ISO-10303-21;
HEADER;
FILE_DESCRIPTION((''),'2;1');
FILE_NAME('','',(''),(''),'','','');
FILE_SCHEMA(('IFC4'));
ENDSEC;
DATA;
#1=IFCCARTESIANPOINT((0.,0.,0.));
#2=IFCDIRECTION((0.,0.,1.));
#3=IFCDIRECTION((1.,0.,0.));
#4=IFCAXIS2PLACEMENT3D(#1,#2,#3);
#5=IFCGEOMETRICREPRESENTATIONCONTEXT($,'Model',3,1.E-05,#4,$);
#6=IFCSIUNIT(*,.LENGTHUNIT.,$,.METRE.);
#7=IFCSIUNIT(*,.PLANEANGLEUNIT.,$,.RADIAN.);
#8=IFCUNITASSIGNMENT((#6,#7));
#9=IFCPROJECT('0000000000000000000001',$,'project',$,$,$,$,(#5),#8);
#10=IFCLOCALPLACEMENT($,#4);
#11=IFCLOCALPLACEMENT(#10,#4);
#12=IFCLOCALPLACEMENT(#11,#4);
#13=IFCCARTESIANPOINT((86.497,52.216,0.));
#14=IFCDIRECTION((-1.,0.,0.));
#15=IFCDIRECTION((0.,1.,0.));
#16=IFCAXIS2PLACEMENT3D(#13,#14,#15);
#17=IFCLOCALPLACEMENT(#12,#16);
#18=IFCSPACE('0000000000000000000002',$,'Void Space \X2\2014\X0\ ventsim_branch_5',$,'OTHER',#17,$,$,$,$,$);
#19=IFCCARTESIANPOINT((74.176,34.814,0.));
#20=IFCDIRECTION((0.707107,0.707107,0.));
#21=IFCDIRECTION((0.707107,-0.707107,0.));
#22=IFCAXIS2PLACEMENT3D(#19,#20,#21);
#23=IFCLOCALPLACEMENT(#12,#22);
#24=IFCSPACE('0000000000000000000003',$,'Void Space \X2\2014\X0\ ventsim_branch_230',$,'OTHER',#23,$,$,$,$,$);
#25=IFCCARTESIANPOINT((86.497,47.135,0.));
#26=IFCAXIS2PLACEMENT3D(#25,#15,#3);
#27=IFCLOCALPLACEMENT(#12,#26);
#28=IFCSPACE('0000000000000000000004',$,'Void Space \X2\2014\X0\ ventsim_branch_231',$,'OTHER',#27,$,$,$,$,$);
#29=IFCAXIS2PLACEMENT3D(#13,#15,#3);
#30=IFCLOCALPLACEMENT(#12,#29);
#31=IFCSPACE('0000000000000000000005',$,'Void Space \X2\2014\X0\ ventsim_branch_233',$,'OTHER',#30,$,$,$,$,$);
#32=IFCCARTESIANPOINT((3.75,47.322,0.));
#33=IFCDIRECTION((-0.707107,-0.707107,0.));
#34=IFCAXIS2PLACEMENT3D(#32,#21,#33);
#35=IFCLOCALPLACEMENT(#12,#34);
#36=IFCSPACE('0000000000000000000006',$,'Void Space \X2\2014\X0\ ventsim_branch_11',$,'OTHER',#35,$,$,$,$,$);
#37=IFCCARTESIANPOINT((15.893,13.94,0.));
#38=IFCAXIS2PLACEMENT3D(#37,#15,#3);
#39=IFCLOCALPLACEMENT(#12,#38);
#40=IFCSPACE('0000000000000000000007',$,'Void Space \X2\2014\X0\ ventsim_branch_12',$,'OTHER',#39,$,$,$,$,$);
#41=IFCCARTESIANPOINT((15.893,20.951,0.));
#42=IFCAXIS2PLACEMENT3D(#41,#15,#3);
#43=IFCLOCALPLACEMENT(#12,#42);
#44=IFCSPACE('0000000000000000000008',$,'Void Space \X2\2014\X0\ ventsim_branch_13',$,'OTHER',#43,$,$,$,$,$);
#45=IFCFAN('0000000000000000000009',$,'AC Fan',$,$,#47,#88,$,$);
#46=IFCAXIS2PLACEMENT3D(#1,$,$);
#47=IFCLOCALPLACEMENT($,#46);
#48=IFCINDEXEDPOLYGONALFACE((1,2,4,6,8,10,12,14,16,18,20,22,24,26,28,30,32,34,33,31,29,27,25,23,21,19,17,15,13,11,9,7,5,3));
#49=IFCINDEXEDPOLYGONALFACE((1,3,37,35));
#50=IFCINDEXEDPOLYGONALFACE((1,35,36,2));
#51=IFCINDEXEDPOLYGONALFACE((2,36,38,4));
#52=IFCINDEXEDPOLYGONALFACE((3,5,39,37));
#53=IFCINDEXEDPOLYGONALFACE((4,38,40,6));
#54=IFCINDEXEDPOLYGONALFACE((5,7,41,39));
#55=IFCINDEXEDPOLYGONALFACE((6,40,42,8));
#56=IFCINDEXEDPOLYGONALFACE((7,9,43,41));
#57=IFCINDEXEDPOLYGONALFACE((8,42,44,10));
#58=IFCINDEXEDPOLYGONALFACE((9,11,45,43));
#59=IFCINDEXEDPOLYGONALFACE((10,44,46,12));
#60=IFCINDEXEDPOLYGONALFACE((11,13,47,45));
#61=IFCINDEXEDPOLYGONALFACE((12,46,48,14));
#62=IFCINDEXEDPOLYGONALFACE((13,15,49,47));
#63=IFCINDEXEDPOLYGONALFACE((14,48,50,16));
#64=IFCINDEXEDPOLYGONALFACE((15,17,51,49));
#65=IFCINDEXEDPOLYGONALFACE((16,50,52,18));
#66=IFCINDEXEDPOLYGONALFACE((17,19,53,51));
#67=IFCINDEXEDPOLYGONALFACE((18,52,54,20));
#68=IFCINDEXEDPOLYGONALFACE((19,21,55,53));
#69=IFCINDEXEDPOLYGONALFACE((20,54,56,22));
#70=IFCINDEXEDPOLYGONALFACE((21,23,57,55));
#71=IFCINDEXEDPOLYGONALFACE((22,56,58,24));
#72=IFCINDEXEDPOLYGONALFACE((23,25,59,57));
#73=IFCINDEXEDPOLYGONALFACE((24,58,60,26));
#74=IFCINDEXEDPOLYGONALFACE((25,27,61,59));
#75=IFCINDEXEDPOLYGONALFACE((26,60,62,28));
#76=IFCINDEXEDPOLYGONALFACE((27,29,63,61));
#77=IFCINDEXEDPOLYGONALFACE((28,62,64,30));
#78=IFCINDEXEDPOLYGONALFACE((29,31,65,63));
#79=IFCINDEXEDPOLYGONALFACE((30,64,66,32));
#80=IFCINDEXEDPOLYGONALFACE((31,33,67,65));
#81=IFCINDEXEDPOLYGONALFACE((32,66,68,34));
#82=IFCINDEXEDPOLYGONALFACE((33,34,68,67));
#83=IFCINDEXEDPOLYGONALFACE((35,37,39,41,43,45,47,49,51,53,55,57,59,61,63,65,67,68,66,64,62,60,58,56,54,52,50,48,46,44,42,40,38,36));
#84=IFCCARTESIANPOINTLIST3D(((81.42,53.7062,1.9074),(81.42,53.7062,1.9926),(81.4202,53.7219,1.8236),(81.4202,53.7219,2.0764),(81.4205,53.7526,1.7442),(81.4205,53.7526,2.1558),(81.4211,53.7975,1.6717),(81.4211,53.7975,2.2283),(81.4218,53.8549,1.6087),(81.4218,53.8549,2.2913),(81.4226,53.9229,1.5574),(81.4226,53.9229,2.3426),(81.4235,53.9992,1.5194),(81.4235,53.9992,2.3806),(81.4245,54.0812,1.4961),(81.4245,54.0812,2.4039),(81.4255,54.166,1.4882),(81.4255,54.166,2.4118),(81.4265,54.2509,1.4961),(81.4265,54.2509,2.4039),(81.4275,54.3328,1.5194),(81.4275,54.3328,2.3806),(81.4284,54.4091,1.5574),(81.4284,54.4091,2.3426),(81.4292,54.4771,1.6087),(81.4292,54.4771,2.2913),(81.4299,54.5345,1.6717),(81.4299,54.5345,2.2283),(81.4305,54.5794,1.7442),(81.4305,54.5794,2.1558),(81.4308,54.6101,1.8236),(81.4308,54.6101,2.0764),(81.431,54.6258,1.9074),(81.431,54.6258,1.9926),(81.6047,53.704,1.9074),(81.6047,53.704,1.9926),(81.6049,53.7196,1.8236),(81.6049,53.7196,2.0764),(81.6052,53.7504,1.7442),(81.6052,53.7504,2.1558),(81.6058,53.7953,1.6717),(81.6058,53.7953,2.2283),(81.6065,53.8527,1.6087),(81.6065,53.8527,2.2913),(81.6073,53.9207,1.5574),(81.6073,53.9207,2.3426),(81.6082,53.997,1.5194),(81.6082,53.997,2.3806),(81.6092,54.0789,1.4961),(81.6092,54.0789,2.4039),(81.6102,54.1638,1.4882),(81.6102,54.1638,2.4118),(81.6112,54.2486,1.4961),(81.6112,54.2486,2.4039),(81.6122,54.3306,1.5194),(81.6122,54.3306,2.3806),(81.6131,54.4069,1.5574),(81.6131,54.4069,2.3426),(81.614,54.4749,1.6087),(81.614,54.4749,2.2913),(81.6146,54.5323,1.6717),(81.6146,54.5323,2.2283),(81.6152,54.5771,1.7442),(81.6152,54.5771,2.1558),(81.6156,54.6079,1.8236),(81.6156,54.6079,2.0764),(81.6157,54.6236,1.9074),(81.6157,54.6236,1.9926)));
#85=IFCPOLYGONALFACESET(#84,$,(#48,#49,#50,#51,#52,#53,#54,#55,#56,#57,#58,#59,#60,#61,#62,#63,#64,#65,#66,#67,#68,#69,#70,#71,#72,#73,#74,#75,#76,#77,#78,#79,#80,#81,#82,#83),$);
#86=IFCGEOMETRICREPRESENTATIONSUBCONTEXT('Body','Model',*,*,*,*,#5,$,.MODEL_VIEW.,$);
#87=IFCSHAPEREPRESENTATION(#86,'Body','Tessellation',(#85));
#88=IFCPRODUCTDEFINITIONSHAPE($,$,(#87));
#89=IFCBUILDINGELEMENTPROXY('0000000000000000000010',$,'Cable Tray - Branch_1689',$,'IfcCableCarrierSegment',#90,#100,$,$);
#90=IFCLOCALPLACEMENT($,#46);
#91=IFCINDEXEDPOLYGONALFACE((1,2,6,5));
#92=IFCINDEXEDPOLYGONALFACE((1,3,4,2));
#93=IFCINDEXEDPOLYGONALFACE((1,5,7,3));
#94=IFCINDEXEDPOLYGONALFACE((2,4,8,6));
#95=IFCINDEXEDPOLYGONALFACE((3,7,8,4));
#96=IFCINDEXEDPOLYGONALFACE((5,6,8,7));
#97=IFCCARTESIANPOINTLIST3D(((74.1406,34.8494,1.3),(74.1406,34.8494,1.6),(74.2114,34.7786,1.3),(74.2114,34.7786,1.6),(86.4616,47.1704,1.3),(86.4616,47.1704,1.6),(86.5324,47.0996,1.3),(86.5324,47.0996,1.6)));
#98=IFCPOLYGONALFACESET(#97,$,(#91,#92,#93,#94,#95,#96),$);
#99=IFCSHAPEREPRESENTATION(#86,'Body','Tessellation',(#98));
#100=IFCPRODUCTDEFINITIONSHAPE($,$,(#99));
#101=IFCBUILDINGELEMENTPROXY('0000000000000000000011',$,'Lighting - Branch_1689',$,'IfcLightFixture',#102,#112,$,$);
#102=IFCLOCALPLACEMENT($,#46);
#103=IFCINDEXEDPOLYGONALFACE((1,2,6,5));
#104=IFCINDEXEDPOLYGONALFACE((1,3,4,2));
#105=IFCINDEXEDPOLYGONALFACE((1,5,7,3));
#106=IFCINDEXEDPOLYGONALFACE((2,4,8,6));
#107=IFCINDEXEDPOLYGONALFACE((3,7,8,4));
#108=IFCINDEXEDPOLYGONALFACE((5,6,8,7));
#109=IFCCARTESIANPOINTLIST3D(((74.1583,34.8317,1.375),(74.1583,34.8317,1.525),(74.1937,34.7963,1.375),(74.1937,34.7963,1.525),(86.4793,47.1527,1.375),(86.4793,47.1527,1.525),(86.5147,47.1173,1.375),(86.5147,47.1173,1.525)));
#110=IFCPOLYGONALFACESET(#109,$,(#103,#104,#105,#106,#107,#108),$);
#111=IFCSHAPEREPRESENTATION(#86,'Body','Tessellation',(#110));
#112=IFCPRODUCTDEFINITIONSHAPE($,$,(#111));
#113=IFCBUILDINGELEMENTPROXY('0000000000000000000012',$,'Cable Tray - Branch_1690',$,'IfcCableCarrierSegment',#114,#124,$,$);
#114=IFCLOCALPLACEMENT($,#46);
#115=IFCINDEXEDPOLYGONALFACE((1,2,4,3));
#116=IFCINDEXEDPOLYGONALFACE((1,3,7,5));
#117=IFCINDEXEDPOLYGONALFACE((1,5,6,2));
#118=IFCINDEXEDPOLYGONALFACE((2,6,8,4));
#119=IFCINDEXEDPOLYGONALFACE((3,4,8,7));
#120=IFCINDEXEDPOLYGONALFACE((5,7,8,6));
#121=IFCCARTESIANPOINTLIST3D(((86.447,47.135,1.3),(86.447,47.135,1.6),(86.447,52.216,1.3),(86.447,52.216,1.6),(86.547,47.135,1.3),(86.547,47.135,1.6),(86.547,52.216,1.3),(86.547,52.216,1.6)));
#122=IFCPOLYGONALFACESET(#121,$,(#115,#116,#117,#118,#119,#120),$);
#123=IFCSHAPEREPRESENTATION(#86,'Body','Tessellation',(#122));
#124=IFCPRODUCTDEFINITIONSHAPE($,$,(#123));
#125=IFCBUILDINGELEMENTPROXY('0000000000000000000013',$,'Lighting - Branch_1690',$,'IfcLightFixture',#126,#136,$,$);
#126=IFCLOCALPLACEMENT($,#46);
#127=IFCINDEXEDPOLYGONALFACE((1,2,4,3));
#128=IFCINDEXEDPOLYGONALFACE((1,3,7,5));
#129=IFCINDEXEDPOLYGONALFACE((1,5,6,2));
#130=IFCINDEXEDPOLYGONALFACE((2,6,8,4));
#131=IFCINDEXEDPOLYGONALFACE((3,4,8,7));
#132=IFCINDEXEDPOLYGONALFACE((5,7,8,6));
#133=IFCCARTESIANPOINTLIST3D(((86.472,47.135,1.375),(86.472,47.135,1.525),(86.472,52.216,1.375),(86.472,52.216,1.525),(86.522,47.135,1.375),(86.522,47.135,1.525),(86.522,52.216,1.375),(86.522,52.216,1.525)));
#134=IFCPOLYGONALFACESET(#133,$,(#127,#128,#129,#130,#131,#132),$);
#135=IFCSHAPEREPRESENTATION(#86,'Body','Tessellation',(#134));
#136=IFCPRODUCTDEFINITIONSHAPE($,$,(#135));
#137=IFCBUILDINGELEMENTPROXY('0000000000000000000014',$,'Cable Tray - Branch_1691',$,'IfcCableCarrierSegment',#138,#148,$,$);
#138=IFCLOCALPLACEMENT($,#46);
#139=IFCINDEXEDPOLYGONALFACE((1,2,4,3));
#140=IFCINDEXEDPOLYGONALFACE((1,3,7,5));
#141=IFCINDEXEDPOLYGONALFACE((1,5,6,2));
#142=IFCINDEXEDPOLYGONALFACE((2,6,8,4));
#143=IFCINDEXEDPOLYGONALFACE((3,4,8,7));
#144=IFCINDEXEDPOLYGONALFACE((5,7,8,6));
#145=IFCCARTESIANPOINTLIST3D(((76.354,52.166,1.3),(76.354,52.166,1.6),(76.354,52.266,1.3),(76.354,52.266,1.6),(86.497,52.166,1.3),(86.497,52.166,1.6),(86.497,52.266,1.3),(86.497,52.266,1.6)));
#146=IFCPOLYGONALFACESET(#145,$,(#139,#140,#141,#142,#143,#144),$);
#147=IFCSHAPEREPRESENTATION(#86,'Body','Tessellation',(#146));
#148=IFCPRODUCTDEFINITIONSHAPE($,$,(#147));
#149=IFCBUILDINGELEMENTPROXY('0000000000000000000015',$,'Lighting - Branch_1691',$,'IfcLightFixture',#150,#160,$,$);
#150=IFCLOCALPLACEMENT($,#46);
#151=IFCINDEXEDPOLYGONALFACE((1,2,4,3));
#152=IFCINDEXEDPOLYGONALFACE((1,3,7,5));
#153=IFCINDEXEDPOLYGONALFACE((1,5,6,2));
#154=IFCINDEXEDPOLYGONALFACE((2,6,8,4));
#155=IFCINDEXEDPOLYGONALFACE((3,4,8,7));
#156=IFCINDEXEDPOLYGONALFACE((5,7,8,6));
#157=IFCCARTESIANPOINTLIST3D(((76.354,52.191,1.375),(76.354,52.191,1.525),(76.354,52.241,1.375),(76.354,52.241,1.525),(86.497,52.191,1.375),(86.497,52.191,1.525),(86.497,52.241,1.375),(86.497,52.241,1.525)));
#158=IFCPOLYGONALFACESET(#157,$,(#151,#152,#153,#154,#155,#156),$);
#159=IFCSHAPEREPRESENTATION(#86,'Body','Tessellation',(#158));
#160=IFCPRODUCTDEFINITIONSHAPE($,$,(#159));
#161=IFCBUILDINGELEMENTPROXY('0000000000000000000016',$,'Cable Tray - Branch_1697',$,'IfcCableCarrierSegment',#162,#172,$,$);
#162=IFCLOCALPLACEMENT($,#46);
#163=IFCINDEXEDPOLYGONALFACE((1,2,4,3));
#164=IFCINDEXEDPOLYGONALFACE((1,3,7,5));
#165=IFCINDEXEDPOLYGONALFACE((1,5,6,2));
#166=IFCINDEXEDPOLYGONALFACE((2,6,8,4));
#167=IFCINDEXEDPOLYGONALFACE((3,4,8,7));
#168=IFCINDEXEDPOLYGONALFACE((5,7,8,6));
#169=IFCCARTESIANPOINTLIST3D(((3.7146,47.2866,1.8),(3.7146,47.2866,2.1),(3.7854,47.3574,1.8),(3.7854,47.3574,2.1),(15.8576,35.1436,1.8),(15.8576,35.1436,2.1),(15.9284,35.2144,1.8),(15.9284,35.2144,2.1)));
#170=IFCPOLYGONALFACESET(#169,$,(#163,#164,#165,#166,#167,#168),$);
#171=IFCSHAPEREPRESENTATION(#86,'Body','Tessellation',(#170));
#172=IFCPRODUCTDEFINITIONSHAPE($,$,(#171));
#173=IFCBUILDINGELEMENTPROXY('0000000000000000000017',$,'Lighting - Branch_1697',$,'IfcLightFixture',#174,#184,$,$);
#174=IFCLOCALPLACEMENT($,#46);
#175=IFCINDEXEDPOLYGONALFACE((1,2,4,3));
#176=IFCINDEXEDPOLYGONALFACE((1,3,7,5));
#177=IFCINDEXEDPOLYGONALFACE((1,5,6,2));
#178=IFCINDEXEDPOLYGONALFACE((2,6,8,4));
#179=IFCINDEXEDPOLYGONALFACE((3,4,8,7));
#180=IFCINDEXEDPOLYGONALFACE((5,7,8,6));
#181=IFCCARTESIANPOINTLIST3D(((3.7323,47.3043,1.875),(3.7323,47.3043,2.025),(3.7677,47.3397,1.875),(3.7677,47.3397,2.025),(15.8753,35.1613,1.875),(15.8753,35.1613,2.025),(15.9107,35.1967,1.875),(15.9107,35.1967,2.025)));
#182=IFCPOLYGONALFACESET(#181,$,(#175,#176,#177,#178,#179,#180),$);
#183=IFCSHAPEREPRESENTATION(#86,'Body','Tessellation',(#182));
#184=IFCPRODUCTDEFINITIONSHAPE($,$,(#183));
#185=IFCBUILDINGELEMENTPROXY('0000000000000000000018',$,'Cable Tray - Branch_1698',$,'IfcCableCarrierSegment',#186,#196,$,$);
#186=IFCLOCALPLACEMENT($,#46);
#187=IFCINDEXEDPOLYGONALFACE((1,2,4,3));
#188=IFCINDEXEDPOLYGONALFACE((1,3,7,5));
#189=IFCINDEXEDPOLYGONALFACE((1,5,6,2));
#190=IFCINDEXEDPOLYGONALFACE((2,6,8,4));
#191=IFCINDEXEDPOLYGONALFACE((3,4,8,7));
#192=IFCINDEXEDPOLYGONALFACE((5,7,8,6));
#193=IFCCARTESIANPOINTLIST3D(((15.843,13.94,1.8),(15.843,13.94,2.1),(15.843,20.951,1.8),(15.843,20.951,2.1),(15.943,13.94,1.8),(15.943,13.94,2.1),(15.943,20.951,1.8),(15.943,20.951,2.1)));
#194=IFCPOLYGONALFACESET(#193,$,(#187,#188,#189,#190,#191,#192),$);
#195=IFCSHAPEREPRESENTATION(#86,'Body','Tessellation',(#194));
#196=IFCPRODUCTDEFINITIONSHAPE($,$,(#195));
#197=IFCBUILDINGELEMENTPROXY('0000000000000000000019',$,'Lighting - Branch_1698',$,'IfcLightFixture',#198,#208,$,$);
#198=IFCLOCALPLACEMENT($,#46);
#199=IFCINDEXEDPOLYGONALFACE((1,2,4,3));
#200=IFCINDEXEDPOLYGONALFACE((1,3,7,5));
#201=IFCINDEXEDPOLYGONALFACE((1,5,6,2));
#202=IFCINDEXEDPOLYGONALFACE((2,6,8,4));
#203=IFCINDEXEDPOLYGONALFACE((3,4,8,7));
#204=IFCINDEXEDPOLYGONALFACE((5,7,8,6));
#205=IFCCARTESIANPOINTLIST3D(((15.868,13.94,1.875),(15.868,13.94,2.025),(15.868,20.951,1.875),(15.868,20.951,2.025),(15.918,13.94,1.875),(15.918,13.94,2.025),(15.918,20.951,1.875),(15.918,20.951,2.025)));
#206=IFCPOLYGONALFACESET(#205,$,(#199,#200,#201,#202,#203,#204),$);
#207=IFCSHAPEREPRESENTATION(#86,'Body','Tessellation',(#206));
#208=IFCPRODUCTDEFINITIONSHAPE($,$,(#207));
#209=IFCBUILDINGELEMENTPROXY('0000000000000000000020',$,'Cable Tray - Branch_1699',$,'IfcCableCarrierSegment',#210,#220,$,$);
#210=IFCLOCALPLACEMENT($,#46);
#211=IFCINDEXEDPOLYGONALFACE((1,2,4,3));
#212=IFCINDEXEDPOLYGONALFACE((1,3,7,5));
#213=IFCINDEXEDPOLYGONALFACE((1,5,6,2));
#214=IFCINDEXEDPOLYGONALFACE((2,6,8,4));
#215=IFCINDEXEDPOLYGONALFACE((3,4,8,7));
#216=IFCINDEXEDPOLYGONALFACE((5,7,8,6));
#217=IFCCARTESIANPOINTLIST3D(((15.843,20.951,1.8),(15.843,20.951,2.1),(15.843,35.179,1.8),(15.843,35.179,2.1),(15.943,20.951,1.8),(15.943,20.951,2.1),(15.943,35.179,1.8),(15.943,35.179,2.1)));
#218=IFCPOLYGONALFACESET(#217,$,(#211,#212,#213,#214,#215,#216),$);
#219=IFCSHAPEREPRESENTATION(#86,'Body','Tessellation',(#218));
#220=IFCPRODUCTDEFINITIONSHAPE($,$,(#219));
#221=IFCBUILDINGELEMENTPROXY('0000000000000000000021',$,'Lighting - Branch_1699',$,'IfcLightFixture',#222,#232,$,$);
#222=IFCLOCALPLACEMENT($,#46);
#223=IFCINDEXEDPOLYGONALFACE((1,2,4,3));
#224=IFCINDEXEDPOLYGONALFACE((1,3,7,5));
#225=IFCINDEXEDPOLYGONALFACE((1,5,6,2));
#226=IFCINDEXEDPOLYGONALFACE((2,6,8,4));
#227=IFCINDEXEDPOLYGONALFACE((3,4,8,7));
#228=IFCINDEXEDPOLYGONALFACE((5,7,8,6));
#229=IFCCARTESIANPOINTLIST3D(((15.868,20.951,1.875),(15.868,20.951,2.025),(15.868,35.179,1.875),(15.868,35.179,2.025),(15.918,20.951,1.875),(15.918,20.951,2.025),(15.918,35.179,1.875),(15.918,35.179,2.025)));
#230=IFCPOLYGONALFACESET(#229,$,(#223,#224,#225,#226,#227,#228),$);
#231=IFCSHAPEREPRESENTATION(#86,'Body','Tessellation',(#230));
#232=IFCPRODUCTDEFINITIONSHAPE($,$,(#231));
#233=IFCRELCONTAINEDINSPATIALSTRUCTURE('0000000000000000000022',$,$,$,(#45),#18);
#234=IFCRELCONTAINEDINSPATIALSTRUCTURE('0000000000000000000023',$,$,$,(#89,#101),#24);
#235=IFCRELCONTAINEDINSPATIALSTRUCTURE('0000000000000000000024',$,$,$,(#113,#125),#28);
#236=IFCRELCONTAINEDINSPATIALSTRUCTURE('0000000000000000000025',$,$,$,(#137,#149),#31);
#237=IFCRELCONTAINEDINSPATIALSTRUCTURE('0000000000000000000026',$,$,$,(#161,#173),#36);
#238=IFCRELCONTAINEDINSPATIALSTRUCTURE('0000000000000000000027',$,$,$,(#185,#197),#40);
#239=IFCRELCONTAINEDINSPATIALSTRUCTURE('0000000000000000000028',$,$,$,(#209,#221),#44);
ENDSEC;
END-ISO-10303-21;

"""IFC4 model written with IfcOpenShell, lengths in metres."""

from ifc_helpers import new_model, si_unit, frame, origin_with_axes, origin_2d_with_axis, place, context, subcontext, project, spatial, rectangle, circle, extrude, element, save


model = new_model("IFC4")

# Units and contexts
model_context = context("Model", 3, precision=1e-05, world=origin_with_axes())
body_context = subcontext(model_context, "Body", "Model", "MODEL_VIEW")
ifc_project = project(units=[si_unit("LENGTHUNIT", "METRE"), si_unit("PLANEANGLEUNIT", "RADIAN")], contexts=[model_context])

# Space
placement_1 = place(None, origin_with_axes())
placement_2 = place(placement_1, origin_with_axes())
placement_3 = place(placement_2, origin_with_axes())
space_1_placement = place(placement_3, frame((86.497, 52.216, 0.0), z_axis=(-1.0, 0.0, 0.0), x_axis=(0.0, 1.0, 0.0)))
space_1 = spatial("IfcSpace", at=space_1_placement, Name="Void Space — ventsim_branch_5", ObjectType="OTHER")

# Fan
fan_placement = place(placement_3, frame((81.4255, 54.166, 1.95), z_axis=(0.999928, -0.012018, 0.0), x_axis=(0.0, 0.0, 1.0)))
element("IfcFan", 1, at=fan_placement, inside=space_1, Name="AC Fan", context=body_context, shape_type="SweptSolid", body=[
    extrude(circle(Radius=0.4618, at=origin_2d_with_axis()), origin_with_axes(), (0.0, 0.0, 1.0), 0.1847),
])

# Shared definitions
space_2_placement = place(placement_3, frame((74.176, 34.814, 0.0), z_axis=(0.707107, 0.707107, 0.0), x_axis=(0.707107, -0.707107, 0.0)))
space_2 = spatial("IfcSpace", at=space_2_placement, Name="Void Space — ventsim_branch_230", ObjectType="OTHER")

# Building element proxies
proxy_1_placement = place(placement_3, frame((74.176, 34.814, 1.45), z_axis=(0.707107, 0.707107, 0.0), x_axis=(0.0, 0.0, 1.0)))
element("IfcBuildingElementProxy", 2, at=proxy_1_placement, inside=space_2, Name="Cable Tray - Branch_1689", ObjectType="IfcCableCarrierSegment", context=body_context, shape_type="SweptSolid", body=[
    extrude(rectangle(XDim=0.3, YDim=0.1, at=origin_2d_with_axis()), origin_with_axes(), (0.0, 0.0, 1.0), 17.4245),
])
proxy_2_placement = place(placement_3, frame((74.176, 34.814, 1.45), z_axis=(0.707107, 0.707107, 0.0), x_axis=(0.0, 0.0, 1.0)))
element("IfcBuildingElementProxy", 3, at=proxy_2_placement, inside=space_2, Name="Lighting - Branch_1689", ObjectType="IfcLightFixture", context=body_context, shape_type="SweptSolid", body=[
    extrude(rectangle(XDim=0.15, YDim=0.05, at=origin_2d_with_axis()), origin_with_axes(), (0.0, 0.0, 1.0), 17.4245),
])

# Shared definitions
space_3_placement = place(placement_3, frame((86.497, 47.135, 0.0), z_axis=(0.0, 1.0, 0.0), x_axis=(1.0, 0.0, 0.0)))
space_3 = spatial("IfcSpace", at=space_3_placement, Name="Void Space — ventsim_branch_231", ObjectType="OTHER")

# Building element proxies
proxy_3_placement = place(placement_3, frame((86.497, 47.135, 1.45), z_axis=(0.0, 1.0, 0.0), x_axis=(0.0, 0.0, 1.0)))
element("IfcBuildingElementProxy", 4, at=proxy_3_placement, inside=space_3, Name="Cable Tray - Branch_1690", ObjectType="IfcCableCarrierSegment", context=body_context, shape_type="SweptSolid", body=[
    extrude(rectangle(XDim=0.3, YDim=0.1, at=origin_2d_with_axis()), origin_with_axes(), (0.0, 0.0, 1.0), 5.081),
])
proxy_4_placement = place(placement_3, frame((86.497, 47.135, 1.45), z_axis=(0.0, 1.0, 0.0), x_axis=(0.0, 0.0, 1.0)))
element("IfcBuildingElementProxy", 5, at=proxy_4_placement, inside=space_3, Name="Lighting - Branch_1690", ObjectType="IfcLightFixture", context=body_context, shape_type="SweptSolid", body=[
    extrude(rectangle(XDim=0.15, YDim=0.05, at=origin_2d_with_axis()), origin_with_axes(), (0.0, 0.0, 1.0), 5.081),
])

# Shared definitions
space_4_placement = place(placement_3, frame((86.497, 52.216, 0.0), z_axis=(0.0, 1.0, 0.0), x_axis=(1.0, 0.0, 0.0)))
space_4 = spatial("IfcSpace", at=space_4_placement, Name="Void Space — ventsim_branch_233", ObjectType="OTHER")

# Building element proxies
proxy_5_placement = place(placement_3, frame((86.497, 52.216, 1.45), z_axis=(-1.0, 0.0, 0.0), x_axis=(0.0, 0.0, 1.0)))
element("IfcBuildingElementProxy", 6, at=proxy_5_placement, inside=space_4, Name="Cable Tray - Branch_1691", ObjectType="IfcCableCarrierSegment", context=body_context, shape_type="SweptSolid", body=[
    extrude(rectangle(XDim=0.3, YDim=0.1, at=origin_2d_with_axis()), origin_with_axes(), (0.0, 0.0, 1.0), 10.143),
])
proxy_6_placement = place(placement_3, frame((86.497, 52.216, 1.45), z_axis=(-1.0, 0.0, 0.0), x_axis=(0.0, 0.0, 1.0)))
element("IfcBuildingElementProxy", 7, at=proxy_6_placement, inside=space_4, Name="Lighting - Branch_1691", ObjectType="IfcLightFixture", context=body_context, shape_type="SweptSolid", body=[
    extrude(rectangle(XDim=0.15, YDim=0.05, at=origin_2d_with_axis()), origin_with_axes(), (0.0, 0.0, 1.0), 10.143),
])

# Shared definitions
space_5_placement = place(placement_3, frame((3.75, 47.322, 0.0), z_axis=(0.707107, -0.707107, 0.0), x_axis=(-0.707107, -0.707107, 0.0)))
space_5 = spatial("IfcSpace", at=space_5_placement, Name="Void Space — ventsim_branch_11", ObjectType="OTHER")

# Building element proxies
proxy_7_placement = place(placement_3, frame((3.75, 47.322, 1.95), z_axis=(0.707107, -0.707107, 0.0), x_axis=(0.0, 0.0, 1.0)))
element("IfcBuildingElementProxy", 8, at=proxy_7_placement, inside=space_5, Name="Cable Tray - Branch_1697", ObjectType="IfcCableCarrierSegment", context=body_context, shape_type="SweptSolid", body=[
    extrude(rectangle(XDim=0.3, YDim=0.1, at=origin_2d_with_axis()), origin_with_axes(), (0.0, 0.0, 1.0), 17.1728),
])
proxy_8_placement = place(placement_3, frame((3.75, 47.322, 1.95), z_axis=(0.707107, -0.707107, 0.0), x_axis=(0.0, 0.0, 1.0)))
element("IfcBuildingElementProxy", 9, at=proxy_8_placement, inside=space_5, Name="Lighting - Branch_1697", ObjectType="IfcLightFixture", context=body_context, shape_type="SweptSolid", body=[
    extrude(rectangle(XDim=0.15, YDim=0.05, at=origin_2d_with_axis()), origin_with_axes(), (0.0, 0.0, 1.0), 17.1728),
])

# Shared definitions
space_6_placement = place(placement_3, frame((15.893, 13.94, 0.0), z_axis=(0.0, 1.0, 0.0), x_axis=(1.0, 0.0, 0.0)))
space_6 = spatial("IfcSpace", at=space_6_placement, Name="Void Space — ventsim_branch_12", ObjectType="OTHER")

# Building element proxies
proxy_9_placement = place(placement_3, frame((15.893, 13.94, 1.95), z_axis=(0.0, 1.0, 0.0), x_axis=(0.0, 0.0, 1.0)))
element("IfcBuildingElementProxy", 10, at=proxy_9_placement, inside=space_6, Name="Cable Tray - Branch_1698", ObjectType="IfcCableCarrierSegment", context=body_context, shape_type="SweptSolid", body=[
    extrude(rectangle(XDim=0.3, YDim=0.1, at=origin_2d_with_axis()), origin_with_axes(), (0.0, 0.0, 1.0), 7.011),
])
proxy_10_placement = place(placement_3, frame((15.893, 13.94, 1.95), z_axis=(0.0, 1.0, 0.0), x_axis=(0.0, 0.0, 1.0)))
element("IfcBuildingElementProxy", 11, at=proxy_10_placement, inside=space_6, Name="Lighting - Branch_1698", ObjectType="IfcLightFixture", context=body_context, shape_type="SweptSolid", body=[
    extrude(rectangle(XDim=0.15, YDim=0.05, at=origin_2d_with_axis()), origin_with_axes(), (0.0, 0.0, 1.0), 7.011),
])

# Shared definitions
space_7_placement = place(placement_3, frame((15.893, 20.951, 0.0), z_axis=(0.0, 1.0, 0.0), x_axis=(1.0, 0.0, 0.0)))
space_7 = spatial("IfcSpace", at=space_7_placement, Name="Void Space — ventsim_branch_13", ObjectType="OTHER")

# Building element proxies
proxy_11_placement = place(placement_3, frame((15.893, 20.951, 1.95), z_axis=(0.0, 1.0, 0.0), x_axis=(0.0, 0.0, 1.0)))
element("IfcBuildingElementProxy", 12, at=proxy_11_placement, inside=space_7, Name="Cable Tray - Branch_1699", ObjectType="IfcCableCarrierSegment", context=body_context, shape_type="SweptSolid", body=[
    extrude(rectangle(XDim=0.3, YDim=0.1, at=origin_2d_with_axis()), origin_with_axes(), (0.0, 0.0, 1.0), 14.228),
])
proxy_12_placement = place(placement_3, frame((15.893, 20.951, 1.95), z_axis=(0.0, 1.0, 0.0), x_axis=(0.0, 0.0, 1.0)))
element("IfcBuildingElementProxy", 13, at=proxy_12_placement, inside=space_7, Name="Lighting - Branch_1699", ObjectType="IfcLightFixture", context=body_context, shape_type="SweptSolid", body=[
    extrude(rectangle(XDim=0.15, YDim=0.05, at=origin_2d_with_axis()), origin_with_axes(), (0.0, 0.0, 1.0), 14.228),
])

save(model, "model.ifc")
